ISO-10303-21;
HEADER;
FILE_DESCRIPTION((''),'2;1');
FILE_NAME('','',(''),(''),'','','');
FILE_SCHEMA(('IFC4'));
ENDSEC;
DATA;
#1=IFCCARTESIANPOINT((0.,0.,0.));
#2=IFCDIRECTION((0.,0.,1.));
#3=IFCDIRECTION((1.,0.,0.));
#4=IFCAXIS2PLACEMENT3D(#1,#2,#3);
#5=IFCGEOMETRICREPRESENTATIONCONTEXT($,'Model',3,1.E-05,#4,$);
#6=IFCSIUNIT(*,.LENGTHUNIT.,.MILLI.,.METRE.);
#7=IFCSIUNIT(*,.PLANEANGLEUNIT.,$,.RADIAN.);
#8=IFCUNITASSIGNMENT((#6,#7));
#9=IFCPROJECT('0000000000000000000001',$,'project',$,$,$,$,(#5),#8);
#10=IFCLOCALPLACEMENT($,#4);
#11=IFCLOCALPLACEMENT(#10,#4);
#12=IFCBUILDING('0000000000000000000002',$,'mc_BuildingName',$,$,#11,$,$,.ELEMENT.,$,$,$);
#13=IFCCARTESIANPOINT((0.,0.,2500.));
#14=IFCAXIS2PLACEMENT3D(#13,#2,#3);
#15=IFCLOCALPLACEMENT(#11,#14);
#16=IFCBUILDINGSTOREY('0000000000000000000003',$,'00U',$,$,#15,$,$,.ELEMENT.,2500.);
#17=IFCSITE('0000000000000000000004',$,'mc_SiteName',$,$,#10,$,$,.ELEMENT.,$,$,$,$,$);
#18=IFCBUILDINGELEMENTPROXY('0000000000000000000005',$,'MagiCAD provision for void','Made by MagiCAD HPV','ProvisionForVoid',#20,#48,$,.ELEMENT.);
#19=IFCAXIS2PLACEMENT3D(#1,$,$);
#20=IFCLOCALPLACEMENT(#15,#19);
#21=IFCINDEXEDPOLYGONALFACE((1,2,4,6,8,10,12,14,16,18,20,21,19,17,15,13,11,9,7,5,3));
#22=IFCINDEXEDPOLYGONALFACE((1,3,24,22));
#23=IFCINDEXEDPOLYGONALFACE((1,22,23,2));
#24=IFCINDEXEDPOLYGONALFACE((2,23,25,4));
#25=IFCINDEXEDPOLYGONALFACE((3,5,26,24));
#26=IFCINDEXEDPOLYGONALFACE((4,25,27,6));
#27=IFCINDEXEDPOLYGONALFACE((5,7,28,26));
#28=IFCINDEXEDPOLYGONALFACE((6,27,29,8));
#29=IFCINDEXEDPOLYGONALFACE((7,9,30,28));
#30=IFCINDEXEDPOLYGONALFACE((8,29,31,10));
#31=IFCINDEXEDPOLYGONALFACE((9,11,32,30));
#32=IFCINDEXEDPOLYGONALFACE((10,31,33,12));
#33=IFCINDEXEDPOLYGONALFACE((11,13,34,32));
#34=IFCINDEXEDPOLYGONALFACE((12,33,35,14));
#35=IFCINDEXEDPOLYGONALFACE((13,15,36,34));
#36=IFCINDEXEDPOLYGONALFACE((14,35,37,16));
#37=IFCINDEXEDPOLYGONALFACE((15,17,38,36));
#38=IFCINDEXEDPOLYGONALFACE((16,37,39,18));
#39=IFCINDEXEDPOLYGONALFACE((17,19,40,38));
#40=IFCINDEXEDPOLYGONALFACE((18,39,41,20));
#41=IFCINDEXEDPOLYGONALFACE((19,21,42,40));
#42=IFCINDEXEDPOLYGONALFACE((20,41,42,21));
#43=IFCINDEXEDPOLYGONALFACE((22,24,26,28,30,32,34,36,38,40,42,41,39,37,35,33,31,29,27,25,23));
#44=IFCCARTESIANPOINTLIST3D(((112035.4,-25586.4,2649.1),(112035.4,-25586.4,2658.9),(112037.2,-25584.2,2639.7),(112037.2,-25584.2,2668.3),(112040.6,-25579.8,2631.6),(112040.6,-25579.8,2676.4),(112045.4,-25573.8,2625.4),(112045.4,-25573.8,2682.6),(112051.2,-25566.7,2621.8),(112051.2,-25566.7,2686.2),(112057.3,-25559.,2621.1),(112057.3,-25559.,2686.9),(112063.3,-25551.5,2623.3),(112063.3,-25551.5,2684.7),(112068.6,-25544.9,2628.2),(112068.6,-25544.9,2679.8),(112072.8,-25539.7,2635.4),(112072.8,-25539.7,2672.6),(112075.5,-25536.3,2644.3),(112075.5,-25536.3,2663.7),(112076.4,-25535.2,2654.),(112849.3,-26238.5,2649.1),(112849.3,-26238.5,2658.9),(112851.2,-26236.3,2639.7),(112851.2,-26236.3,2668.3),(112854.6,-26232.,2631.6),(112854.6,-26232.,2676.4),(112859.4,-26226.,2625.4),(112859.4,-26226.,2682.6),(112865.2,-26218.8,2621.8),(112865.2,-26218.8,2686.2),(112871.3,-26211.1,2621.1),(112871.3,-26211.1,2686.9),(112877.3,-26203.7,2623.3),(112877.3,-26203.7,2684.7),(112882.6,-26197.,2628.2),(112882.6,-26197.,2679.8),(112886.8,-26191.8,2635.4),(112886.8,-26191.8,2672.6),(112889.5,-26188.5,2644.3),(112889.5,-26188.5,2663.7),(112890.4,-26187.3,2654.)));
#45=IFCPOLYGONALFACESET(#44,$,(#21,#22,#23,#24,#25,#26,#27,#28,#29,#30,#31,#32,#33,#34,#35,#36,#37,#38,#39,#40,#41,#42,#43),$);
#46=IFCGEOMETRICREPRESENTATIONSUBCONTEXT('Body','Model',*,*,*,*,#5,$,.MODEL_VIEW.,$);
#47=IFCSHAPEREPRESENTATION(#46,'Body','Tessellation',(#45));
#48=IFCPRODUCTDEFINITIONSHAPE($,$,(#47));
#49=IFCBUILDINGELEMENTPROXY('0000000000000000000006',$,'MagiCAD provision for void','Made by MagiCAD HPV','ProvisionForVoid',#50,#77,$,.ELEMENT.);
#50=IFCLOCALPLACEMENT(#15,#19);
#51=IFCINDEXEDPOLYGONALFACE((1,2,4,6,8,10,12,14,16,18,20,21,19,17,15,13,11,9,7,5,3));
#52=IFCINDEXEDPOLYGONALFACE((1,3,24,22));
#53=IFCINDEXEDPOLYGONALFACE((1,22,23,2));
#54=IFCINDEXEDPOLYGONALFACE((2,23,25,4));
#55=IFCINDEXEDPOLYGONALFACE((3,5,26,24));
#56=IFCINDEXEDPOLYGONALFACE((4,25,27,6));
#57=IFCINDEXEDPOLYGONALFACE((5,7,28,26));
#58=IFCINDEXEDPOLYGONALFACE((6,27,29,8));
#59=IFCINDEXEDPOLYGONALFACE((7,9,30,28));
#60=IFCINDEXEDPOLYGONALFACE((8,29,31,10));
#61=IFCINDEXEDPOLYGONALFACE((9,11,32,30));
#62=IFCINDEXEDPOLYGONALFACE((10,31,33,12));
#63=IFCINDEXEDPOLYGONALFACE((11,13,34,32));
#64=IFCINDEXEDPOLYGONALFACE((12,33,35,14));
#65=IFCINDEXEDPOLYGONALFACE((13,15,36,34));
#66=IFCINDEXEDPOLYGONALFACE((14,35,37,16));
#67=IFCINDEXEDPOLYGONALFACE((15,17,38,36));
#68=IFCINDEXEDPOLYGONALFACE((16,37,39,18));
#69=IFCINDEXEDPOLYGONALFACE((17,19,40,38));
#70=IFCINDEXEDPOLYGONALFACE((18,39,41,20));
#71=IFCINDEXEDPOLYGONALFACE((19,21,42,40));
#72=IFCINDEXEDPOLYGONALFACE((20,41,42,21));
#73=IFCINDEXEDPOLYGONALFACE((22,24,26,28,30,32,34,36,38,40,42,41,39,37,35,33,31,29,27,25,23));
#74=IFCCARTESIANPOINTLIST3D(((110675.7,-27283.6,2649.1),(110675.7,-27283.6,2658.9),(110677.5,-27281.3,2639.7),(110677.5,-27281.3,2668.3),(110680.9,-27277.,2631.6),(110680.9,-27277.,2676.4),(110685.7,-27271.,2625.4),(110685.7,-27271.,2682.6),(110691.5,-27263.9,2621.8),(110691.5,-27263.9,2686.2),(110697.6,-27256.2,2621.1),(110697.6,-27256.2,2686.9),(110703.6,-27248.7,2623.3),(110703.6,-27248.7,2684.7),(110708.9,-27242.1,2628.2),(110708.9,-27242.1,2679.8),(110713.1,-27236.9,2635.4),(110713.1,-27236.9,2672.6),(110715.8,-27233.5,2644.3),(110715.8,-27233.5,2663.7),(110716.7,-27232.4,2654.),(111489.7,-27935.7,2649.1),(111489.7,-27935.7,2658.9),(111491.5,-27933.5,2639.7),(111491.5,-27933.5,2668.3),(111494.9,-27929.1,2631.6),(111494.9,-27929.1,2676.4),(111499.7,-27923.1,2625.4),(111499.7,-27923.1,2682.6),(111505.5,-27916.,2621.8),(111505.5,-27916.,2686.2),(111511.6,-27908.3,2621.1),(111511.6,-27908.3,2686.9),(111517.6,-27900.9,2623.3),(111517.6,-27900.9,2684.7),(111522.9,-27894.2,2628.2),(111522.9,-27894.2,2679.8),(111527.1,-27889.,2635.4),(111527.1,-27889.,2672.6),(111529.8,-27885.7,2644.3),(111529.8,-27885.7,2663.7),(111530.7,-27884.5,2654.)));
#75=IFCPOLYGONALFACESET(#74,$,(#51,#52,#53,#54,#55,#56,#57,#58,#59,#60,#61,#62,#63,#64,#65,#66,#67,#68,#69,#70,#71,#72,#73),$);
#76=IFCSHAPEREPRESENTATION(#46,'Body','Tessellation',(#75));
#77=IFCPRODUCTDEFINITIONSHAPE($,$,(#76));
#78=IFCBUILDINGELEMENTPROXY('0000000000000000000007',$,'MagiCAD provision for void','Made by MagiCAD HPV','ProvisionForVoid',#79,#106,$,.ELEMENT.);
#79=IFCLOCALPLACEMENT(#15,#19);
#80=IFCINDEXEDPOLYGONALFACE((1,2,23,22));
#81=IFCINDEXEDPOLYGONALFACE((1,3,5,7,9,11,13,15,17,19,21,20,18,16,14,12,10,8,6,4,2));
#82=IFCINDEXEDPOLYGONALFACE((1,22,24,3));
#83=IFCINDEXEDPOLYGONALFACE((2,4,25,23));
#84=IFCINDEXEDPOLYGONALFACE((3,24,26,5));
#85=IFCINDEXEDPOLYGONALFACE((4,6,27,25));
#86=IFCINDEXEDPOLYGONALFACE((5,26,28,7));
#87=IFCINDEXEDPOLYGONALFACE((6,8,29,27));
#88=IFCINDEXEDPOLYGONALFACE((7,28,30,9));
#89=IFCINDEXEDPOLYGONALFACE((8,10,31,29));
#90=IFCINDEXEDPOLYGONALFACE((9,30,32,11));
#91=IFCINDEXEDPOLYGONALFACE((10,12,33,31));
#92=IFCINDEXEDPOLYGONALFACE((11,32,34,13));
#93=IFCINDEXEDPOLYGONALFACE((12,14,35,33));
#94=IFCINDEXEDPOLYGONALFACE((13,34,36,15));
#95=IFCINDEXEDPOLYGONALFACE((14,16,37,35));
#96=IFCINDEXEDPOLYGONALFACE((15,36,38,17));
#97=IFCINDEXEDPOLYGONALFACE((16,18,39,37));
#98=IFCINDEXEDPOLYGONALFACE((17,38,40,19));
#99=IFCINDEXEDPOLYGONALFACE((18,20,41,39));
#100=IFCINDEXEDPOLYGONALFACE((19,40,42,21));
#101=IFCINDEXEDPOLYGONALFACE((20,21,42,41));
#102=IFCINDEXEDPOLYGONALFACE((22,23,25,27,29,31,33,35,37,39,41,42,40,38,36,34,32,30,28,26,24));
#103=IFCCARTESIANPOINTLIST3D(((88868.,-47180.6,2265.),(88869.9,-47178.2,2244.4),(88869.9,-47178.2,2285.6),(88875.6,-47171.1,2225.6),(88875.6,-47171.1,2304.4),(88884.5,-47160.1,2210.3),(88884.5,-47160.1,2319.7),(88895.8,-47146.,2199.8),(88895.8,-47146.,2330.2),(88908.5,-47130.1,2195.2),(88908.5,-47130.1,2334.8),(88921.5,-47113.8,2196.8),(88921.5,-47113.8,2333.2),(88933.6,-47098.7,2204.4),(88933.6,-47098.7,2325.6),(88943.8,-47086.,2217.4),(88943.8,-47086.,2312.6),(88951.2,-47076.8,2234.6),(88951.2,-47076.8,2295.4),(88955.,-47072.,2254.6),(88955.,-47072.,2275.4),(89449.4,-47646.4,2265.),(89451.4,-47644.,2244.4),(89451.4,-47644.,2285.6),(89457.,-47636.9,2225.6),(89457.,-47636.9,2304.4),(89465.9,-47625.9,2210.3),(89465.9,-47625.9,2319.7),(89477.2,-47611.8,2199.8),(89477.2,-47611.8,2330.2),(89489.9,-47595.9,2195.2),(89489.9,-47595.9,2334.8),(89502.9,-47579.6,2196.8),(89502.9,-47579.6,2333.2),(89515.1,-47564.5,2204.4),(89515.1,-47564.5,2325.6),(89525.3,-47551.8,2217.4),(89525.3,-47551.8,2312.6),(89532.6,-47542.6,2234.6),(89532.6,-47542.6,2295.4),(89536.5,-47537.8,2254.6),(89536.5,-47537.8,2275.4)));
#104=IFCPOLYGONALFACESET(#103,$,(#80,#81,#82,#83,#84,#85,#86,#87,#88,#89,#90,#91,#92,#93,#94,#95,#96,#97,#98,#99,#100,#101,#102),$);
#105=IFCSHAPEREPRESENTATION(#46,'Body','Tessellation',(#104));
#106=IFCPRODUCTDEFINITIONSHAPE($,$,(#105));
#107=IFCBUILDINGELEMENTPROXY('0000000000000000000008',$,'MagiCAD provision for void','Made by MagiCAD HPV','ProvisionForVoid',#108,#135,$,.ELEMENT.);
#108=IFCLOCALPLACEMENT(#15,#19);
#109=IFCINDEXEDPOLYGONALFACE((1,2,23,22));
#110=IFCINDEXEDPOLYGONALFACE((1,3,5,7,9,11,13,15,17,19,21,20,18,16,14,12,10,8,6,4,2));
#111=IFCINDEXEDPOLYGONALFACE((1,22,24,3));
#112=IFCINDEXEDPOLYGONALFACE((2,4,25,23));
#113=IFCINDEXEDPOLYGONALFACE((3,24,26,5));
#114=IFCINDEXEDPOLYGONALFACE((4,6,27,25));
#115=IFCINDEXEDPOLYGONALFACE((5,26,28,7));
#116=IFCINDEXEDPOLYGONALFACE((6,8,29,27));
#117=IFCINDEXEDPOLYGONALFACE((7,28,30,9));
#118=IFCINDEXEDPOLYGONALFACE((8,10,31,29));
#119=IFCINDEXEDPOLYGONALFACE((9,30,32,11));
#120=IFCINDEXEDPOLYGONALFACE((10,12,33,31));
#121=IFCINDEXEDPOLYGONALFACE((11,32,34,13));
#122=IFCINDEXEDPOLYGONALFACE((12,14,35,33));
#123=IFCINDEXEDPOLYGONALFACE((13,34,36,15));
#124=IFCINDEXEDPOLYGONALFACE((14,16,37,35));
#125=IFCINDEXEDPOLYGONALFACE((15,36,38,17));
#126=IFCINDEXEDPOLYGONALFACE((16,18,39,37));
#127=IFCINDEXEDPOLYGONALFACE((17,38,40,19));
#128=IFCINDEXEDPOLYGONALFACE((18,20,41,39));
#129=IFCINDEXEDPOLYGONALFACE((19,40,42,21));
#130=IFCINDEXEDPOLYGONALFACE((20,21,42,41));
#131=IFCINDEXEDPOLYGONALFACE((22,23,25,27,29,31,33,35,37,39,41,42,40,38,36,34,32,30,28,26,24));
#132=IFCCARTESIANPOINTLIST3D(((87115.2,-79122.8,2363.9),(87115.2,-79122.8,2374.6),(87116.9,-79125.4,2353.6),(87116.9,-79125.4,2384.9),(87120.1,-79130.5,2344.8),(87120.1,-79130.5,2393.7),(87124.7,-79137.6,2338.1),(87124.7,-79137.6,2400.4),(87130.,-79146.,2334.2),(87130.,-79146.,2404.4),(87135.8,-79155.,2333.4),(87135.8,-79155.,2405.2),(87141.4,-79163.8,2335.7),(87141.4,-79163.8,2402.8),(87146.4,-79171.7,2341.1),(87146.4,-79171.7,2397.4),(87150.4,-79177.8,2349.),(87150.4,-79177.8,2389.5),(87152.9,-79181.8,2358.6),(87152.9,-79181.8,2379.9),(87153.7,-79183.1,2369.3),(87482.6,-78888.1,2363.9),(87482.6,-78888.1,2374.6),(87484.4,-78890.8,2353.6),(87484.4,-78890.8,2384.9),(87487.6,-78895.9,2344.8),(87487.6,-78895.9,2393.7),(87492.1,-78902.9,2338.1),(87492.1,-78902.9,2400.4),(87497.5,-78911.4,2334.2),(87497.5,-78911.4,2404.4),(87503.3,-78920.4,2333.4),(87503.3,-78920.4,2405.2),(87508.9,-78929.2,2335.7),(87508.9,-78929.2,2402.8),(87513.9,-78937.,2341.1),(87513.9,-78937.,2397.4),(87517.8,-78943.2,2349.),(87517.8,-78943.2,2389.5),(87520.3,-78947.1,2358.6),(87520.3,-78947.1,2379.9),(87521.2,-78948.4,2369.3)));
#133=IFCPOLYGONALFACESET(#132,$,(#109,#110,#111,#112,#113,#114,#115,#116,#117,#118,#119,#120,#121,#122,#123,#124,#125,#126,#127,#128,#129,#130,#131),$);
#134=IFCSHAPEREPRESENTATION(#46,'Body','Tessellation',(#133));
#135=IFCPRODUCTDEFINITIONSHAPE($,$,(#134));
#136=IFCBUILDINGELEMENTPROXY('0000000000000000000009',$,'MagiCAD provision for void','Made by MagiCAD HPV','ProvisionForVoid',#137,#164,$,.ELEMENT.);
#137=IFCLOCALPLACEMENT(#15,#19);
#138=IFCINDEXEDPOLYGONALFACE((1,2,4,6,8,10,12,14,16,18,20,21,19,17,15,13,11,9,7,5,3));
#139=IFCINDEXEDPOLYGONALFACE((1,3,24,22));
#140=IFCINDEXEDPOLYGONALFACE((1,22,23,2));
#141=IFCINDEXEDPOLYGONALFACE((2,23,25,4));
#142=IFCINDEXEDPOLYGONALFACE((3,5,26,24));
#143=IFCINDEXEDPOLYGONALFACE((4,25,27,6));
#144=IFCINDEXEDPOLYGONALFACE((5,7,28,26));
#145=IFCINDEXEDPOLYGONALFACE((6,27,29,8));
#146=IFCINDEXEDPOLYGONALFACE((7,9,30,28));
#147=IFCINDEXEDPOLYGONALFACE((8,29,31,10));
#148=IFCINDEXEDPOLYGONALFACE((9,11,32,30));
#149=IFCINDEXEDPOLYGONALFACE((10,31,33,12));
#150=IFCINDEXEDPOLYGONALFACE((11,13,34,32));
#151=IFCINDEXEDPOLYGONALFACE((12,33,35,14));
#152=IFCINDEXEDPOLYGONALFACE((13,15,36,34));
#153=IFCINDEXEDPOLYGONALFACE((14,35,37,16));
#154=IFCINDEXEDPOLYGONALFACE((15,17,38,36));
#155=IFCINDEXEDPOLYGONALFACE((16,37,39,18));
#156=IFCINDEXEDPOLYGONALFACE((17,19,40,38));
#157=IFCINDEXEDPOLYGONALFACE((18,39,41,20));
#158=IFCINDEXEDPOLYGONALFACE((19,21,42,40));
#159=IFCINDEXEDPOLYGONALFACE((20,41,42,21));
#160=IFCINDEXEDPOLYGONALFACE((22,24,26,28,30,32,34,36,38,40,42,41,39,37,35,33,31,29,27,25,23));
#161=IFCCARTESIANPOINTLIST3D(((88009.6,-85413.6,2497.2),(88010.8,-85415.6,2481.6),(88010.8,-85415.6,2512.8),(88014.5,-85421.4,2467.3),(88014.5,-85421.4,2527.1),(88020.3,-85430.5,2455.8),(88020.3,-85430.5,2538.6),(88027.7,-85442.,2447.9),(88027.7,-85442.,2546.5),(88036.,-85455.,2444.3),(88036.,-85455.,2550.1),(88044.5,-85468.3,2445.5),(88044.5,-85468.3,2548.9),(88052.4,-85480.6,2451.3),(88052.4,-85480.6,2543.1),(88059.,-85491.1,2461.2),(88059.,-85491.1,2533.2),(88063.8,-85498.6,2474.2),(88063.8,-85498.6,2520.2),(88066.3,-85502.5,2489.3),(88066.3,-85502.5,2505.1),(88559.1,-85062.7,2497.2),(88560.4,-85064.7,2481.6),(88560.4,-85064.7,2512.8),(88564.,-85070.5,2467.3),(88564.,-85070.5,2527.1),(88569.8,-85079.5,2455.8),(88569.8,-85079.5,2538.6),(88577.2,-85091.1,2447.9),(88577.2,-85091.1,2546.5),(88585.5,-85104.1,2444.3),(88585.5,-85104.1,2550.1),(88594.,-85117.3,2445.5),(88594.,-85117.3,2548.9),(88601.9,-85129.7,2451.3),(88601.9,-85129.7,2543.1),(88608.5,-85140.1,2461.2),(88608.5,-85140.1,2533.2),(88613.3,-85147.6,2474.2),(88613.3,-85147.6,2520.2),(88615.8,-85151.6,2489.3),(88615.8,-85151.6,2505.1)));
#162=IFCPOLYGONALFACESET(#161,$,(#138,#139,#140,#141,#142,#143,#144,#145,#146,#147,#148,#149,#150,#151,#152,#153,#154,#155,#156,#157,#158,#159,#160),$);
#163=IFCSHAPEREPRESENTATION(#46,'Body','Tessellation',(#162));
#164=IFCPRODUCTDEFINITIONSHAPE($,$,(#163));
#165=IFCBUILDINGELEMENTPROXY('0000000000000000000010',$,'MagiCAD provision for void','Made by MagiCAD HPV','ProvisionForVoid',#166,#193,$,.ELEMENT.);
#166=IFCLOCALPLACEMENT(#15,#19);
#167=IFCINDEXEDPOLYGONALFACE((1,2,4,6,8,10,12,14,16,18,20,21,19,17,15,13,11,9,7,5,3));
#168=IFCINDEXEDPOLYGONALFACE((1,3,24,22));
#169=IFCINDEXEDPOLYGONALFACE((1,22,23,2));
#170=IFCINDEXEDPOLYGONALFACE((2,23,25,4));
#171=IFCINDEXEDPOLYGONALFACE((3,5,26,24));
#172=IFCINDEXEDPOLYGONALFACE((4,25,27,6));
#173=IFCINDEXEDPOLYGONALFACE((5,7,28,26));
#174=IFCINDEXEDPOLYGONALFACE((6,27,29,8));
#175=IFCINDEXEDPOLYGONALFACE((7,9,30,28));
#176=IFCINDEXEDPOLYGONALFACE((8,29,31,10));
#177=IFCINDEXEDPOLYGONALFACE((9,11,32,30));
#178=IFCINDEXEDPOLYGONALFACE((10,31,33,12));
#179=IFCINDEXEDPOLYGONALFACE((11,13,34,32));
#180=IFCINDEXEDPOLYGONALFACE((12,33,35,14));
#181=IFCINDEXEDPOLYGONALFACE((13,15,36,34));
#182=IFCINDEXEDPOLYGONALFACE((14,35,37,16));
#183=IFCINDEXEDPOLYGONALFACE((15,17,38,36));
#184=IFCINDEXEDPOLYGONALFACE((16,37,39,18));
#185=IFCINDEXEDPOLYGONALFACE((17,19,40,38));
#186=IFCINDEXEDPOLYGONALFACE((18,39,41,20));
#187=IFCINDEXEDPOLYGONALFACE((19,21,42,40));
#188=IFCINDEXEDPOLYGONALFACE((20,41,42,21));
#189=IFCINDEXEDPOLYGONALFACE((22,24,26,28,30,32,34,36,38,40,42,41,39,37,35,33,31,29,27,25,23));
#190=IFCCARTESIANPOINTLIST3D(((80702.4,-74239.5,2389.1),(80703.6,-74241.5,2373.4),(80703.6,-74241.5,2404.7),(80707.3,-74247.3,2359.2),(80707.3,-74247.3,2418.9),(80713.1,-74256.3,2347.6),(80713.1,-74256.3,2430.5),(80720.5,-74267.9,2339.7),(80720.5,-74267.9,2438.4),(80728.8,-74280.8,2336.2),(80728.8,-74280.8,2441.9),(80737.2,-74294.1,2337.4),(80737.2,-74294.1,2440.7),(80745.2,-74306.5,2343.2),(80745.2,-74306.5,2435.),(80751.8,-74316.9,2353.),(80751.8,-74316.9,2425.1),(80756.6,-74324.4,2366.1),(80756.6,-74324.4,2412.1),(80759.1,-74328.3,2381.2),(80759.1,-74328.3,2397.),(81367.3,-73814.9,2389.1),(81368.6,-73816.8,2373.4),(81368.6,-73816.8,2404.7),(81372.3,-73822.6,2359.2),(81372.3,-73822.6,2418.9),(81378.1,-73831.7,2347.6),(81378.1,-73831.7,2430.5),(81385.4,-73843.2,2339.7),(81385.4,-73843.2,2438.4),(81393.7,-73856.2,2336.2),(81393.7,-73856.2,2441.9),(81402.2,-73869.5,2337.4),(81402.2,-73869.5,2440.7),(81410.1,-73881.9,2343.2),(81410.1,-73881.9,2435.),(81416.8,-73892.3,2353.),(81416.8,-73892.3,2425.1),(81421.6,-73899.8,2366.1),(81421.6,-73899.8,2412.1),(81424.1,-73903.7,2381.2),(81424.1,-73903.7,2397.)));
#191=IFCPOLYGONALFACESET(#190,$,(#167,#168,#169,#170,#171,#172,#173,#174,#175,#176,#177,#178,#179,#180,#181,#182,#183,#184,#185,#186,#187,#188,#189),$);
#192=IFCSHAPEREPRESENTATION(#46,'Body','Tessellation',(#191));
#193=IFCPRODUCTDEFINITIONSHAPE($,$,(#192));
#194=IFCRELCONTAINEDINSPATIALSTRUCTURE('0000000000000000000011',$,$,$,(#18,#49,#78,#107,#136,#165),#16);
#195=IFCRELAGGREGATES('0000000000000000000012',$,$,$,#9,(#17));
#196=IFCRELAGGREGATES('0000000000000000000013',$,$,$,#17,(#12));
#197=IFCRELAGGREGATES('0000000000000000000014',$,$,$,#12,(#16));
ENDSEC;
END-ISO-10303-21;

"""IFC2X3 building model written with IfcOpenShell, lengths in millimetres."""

from ifc_helpers import new_model, si_unit, frame, origin_with_axes, origin_2d_with_axis, place, context, subcontext, project, spatial, circle, extrude, source, transform, mapped, element, save


model = new_model("IFC2X3")

# Units and contexts
model_context = context("Model", 3, precision=1e-05, world=origin_with_axes())
body_context = subcontext(model_context, "Body", "Model", "MODEL_VIEW")
ifc_project = project(units=[si_unit("LENGTHUNIT", "METRE", prefix="MILLI"), si_unit("PLANEANGLEUNIT", "RADIAN")], contexts=[model_context])

# Site, building, storey
site_placement = place(None, origin_with_axes())
site = spatial("IfcSite", under=ifc_project, at=site_placement, Name="mc_SiteName", CompositionType="ELEMENT")
building_placement = place(site_placement, origin_with_axes())
building = spatial("IfcBuilding", under=site, at=building_placement, Name="mc_BuildingName", CompositionType="ELEMENT")
storey_placement = place(building_placement, frame((0.0, 0.0, 2500.0), z_axis=(0.0, 0.0, 1.0), x_axis=(1.0, 0.0, 0.0)))
storey = spatial("IfcBuildingStorey", under=building, at=storey_placement, Name="00U", CompositionType="ELEMENT", Elevation=2500.0)

# Building element proxies
shared_shape_1 = source(origin_with_axes(), body_context, "Body", "SweptSolid", [
    extrude(circle(Radius=33.0, at=origin_2d_with_axis()), frame((0.0, 0.0, 0.0), z_axis=(1.0, 0.0, 0.0), x_axis=(0.0, 1.0, 0.0)), (0.0, 0.0, 1.0), 1043.0),
])
proxy_1_placement = place(storey_placement, frame((112055.8, -25560.9, 2654.0), z_axis=(0.0, 0.0, 1.0), x_axis=(0.780434, -0.625238, 0.0)))
element("IfcBuildingElementProxy", 1, at=proxy_1_placement, inside=storey, Name="MagiCAD provision for void", Description="Made by MagiCAD HPV", ObjectType="ProvisionForVoid", CompositionType="ELEMENT", context=body_context, shape_type="MappedRepresentation", body=[
    mapped(shared_shape_1, transform((0.0, 0.0, 0.0), scale=1.0)),
])
shared_shape_2 = source(origin_with_axes(), body_context, "Body", "SweptSolid", [
    extrude(circle(Radius=33.0, at=origin_2d_with_axis()), frame((0.0, 0.0, 0.0), z_axis=(1.0, 0.0, 0.0), x_axis=(0.0, 1.0, 0.0)), (0.0, 0.0, 1.0), 1043.0),
])
proxy_2_placement = place(storey_placement, frame((110696.1, -27258.1, 2654.0), z_axis=(0.0, 0.0, 1.0), x_axis=(0.780434, -0.625238, 0.0)))
element("IfcBuildingElementProxy", 2, at=proxy_2_placement, inside=storey, Name="MagiCAD provision for void", Description="Made by MagiCAD HPV", ObjectType="ProvisionForVoid", CompositionType="ELEMENT", context=body_context, shape_type="MappedRepresentation", body=[
    mapped(shared_shape_2, transform((0.0, 0.0, 0.0), scale=1.0)),
])
shared_shape_3 = source(origin_with_axes(), body_context, "Body", "SweptSolid", [
    extrude(circle(Radius=70.0, at=origin_2d_with_axis()), frame((0.0, 0.0, 0.0), z_axis=(1.0, 0.0, 0.0), x_axis=(0.0, 1.0, 0.0)), (0.0, 0.0, 1.0), 745.0),
])
proxy_3_placement = place(storey_placement, frame((89493.2, -47591.8, 2265.0), z_axis=(0.0, 0.0, 1.0), x_axis=(-0.780434, 0.625238, 0.0)))
element("IfcBuildingElementProxy", 3, at=proxy_3_placement, inside=storey, Name="MagiCAD provision for void", Description="Made by MagiCAD HPV", ObjectType="ProvisionForVoid", CompositionType="ELEMENT", context=body_context, shape_type="MappedRepresentation", body=[
    mapped(shared_shape_3, transform((0.0, 0.0, 0.0), scale=1.0)),
])
shared_shape_4 = source(origin_with_axes(), body_context, "Body", "SweptSolid", [
    extrude(circle(Radius=36.0, at=origin_2d_with_axis()), frame((0.0, 0.0, 0.0), z_axis=(1.0, 0.0, 0.0), x_axis=(0.0, 1.0, 0.0)), (0.0, 0.0, 1.0), 436.0),
])
proxy_4_placement = place(storey_placement, frame((87501.8, -78918.1, 2369.3), z_axis=(0.0, 0.0, 1.0), x_axis=(-0.842809, -0.538213, 0.0)))
element("IfcBuildingElementProxy", 4, at=proxy_4_placement, inside=storey, Name="MagiCAD provision for void", Description="Made by MagiCAD HPV", ObjectType="ProvisionForVoid", CompositionType="ELEMENT", context=body_context, shape_type="MappedRepresentation", body=[
    mapped(shared_shape_4, transform((0.0, 0.0, 0.0), scale=1.0)),
])
shared_shape_5 = source(origin_with_axes(), body_context, "Body", "SweptSolid", [
    extrude(circle(Radius=53.0, at=origin_2d_with_axis()), frame((0.0, 0.0, 0.0), z_axis=(1.0, 0.0, 0.0), x_axis=(0.0, 1.0, 0.0)), (0.0, 0.0, 1.0), 652.0),
])
proxy_5_placement = place(storey_placement, frame((88038.1, -85458.3, 2497.2), z_axis=(0.0, 0.0, 1.0), x_axis=(0.842809, 0.538213, 0.0)))
element("IfcBuildingElementProxy", 5, at=proxy_5_placement, inside=storey, Name="MagiCAD provision for void", Description="Made by MagiCAD HPV", ObjectType="ProvisionForVoid", CompositionType="ELEMENT", context=body_context, shape_type="MappedRepresentation", body=[
    mapped(shared_shape_5, transform((0.0, 0.0, 0.0), scale=1.0)),
])
shared_shape_6 = source(origin_with_axes(), body_context, "Body", "SweptSolid", [
    extrude(circle(Radius=53.0, at=origin_2d_with_axis()), frame((0.0, 0.0, 0.0), z_axis=(1.0, 0.0, 0.0), x_axis=(0.0, 1.0, 0.0)), (0.0, 0.0, 1.0), 789.0),
])
proxy_6_placement = place(storey_placement, frame((80730.9, -74284.2, 2389.1), z_axis=(0.0, 0.0, 1.0), x_axis=(0.842809, 0.538213, 0.0)))
element("IfcBuildingElementProxy", 6, at=proxy_6_placement, inside=storey, Name="MagiCAD provision for void", Description="Made by MagiCAD HPV", ObjectType="ProvisionForVoid", CompositionType="ELEMENT", context=body_context, shape_type="MappedRepresentation", body=[
    mapped(shared_shape_6, transform((0.0, 0.0, 0.0), scale=1.0)),
])

save(model, "model.ifc")
